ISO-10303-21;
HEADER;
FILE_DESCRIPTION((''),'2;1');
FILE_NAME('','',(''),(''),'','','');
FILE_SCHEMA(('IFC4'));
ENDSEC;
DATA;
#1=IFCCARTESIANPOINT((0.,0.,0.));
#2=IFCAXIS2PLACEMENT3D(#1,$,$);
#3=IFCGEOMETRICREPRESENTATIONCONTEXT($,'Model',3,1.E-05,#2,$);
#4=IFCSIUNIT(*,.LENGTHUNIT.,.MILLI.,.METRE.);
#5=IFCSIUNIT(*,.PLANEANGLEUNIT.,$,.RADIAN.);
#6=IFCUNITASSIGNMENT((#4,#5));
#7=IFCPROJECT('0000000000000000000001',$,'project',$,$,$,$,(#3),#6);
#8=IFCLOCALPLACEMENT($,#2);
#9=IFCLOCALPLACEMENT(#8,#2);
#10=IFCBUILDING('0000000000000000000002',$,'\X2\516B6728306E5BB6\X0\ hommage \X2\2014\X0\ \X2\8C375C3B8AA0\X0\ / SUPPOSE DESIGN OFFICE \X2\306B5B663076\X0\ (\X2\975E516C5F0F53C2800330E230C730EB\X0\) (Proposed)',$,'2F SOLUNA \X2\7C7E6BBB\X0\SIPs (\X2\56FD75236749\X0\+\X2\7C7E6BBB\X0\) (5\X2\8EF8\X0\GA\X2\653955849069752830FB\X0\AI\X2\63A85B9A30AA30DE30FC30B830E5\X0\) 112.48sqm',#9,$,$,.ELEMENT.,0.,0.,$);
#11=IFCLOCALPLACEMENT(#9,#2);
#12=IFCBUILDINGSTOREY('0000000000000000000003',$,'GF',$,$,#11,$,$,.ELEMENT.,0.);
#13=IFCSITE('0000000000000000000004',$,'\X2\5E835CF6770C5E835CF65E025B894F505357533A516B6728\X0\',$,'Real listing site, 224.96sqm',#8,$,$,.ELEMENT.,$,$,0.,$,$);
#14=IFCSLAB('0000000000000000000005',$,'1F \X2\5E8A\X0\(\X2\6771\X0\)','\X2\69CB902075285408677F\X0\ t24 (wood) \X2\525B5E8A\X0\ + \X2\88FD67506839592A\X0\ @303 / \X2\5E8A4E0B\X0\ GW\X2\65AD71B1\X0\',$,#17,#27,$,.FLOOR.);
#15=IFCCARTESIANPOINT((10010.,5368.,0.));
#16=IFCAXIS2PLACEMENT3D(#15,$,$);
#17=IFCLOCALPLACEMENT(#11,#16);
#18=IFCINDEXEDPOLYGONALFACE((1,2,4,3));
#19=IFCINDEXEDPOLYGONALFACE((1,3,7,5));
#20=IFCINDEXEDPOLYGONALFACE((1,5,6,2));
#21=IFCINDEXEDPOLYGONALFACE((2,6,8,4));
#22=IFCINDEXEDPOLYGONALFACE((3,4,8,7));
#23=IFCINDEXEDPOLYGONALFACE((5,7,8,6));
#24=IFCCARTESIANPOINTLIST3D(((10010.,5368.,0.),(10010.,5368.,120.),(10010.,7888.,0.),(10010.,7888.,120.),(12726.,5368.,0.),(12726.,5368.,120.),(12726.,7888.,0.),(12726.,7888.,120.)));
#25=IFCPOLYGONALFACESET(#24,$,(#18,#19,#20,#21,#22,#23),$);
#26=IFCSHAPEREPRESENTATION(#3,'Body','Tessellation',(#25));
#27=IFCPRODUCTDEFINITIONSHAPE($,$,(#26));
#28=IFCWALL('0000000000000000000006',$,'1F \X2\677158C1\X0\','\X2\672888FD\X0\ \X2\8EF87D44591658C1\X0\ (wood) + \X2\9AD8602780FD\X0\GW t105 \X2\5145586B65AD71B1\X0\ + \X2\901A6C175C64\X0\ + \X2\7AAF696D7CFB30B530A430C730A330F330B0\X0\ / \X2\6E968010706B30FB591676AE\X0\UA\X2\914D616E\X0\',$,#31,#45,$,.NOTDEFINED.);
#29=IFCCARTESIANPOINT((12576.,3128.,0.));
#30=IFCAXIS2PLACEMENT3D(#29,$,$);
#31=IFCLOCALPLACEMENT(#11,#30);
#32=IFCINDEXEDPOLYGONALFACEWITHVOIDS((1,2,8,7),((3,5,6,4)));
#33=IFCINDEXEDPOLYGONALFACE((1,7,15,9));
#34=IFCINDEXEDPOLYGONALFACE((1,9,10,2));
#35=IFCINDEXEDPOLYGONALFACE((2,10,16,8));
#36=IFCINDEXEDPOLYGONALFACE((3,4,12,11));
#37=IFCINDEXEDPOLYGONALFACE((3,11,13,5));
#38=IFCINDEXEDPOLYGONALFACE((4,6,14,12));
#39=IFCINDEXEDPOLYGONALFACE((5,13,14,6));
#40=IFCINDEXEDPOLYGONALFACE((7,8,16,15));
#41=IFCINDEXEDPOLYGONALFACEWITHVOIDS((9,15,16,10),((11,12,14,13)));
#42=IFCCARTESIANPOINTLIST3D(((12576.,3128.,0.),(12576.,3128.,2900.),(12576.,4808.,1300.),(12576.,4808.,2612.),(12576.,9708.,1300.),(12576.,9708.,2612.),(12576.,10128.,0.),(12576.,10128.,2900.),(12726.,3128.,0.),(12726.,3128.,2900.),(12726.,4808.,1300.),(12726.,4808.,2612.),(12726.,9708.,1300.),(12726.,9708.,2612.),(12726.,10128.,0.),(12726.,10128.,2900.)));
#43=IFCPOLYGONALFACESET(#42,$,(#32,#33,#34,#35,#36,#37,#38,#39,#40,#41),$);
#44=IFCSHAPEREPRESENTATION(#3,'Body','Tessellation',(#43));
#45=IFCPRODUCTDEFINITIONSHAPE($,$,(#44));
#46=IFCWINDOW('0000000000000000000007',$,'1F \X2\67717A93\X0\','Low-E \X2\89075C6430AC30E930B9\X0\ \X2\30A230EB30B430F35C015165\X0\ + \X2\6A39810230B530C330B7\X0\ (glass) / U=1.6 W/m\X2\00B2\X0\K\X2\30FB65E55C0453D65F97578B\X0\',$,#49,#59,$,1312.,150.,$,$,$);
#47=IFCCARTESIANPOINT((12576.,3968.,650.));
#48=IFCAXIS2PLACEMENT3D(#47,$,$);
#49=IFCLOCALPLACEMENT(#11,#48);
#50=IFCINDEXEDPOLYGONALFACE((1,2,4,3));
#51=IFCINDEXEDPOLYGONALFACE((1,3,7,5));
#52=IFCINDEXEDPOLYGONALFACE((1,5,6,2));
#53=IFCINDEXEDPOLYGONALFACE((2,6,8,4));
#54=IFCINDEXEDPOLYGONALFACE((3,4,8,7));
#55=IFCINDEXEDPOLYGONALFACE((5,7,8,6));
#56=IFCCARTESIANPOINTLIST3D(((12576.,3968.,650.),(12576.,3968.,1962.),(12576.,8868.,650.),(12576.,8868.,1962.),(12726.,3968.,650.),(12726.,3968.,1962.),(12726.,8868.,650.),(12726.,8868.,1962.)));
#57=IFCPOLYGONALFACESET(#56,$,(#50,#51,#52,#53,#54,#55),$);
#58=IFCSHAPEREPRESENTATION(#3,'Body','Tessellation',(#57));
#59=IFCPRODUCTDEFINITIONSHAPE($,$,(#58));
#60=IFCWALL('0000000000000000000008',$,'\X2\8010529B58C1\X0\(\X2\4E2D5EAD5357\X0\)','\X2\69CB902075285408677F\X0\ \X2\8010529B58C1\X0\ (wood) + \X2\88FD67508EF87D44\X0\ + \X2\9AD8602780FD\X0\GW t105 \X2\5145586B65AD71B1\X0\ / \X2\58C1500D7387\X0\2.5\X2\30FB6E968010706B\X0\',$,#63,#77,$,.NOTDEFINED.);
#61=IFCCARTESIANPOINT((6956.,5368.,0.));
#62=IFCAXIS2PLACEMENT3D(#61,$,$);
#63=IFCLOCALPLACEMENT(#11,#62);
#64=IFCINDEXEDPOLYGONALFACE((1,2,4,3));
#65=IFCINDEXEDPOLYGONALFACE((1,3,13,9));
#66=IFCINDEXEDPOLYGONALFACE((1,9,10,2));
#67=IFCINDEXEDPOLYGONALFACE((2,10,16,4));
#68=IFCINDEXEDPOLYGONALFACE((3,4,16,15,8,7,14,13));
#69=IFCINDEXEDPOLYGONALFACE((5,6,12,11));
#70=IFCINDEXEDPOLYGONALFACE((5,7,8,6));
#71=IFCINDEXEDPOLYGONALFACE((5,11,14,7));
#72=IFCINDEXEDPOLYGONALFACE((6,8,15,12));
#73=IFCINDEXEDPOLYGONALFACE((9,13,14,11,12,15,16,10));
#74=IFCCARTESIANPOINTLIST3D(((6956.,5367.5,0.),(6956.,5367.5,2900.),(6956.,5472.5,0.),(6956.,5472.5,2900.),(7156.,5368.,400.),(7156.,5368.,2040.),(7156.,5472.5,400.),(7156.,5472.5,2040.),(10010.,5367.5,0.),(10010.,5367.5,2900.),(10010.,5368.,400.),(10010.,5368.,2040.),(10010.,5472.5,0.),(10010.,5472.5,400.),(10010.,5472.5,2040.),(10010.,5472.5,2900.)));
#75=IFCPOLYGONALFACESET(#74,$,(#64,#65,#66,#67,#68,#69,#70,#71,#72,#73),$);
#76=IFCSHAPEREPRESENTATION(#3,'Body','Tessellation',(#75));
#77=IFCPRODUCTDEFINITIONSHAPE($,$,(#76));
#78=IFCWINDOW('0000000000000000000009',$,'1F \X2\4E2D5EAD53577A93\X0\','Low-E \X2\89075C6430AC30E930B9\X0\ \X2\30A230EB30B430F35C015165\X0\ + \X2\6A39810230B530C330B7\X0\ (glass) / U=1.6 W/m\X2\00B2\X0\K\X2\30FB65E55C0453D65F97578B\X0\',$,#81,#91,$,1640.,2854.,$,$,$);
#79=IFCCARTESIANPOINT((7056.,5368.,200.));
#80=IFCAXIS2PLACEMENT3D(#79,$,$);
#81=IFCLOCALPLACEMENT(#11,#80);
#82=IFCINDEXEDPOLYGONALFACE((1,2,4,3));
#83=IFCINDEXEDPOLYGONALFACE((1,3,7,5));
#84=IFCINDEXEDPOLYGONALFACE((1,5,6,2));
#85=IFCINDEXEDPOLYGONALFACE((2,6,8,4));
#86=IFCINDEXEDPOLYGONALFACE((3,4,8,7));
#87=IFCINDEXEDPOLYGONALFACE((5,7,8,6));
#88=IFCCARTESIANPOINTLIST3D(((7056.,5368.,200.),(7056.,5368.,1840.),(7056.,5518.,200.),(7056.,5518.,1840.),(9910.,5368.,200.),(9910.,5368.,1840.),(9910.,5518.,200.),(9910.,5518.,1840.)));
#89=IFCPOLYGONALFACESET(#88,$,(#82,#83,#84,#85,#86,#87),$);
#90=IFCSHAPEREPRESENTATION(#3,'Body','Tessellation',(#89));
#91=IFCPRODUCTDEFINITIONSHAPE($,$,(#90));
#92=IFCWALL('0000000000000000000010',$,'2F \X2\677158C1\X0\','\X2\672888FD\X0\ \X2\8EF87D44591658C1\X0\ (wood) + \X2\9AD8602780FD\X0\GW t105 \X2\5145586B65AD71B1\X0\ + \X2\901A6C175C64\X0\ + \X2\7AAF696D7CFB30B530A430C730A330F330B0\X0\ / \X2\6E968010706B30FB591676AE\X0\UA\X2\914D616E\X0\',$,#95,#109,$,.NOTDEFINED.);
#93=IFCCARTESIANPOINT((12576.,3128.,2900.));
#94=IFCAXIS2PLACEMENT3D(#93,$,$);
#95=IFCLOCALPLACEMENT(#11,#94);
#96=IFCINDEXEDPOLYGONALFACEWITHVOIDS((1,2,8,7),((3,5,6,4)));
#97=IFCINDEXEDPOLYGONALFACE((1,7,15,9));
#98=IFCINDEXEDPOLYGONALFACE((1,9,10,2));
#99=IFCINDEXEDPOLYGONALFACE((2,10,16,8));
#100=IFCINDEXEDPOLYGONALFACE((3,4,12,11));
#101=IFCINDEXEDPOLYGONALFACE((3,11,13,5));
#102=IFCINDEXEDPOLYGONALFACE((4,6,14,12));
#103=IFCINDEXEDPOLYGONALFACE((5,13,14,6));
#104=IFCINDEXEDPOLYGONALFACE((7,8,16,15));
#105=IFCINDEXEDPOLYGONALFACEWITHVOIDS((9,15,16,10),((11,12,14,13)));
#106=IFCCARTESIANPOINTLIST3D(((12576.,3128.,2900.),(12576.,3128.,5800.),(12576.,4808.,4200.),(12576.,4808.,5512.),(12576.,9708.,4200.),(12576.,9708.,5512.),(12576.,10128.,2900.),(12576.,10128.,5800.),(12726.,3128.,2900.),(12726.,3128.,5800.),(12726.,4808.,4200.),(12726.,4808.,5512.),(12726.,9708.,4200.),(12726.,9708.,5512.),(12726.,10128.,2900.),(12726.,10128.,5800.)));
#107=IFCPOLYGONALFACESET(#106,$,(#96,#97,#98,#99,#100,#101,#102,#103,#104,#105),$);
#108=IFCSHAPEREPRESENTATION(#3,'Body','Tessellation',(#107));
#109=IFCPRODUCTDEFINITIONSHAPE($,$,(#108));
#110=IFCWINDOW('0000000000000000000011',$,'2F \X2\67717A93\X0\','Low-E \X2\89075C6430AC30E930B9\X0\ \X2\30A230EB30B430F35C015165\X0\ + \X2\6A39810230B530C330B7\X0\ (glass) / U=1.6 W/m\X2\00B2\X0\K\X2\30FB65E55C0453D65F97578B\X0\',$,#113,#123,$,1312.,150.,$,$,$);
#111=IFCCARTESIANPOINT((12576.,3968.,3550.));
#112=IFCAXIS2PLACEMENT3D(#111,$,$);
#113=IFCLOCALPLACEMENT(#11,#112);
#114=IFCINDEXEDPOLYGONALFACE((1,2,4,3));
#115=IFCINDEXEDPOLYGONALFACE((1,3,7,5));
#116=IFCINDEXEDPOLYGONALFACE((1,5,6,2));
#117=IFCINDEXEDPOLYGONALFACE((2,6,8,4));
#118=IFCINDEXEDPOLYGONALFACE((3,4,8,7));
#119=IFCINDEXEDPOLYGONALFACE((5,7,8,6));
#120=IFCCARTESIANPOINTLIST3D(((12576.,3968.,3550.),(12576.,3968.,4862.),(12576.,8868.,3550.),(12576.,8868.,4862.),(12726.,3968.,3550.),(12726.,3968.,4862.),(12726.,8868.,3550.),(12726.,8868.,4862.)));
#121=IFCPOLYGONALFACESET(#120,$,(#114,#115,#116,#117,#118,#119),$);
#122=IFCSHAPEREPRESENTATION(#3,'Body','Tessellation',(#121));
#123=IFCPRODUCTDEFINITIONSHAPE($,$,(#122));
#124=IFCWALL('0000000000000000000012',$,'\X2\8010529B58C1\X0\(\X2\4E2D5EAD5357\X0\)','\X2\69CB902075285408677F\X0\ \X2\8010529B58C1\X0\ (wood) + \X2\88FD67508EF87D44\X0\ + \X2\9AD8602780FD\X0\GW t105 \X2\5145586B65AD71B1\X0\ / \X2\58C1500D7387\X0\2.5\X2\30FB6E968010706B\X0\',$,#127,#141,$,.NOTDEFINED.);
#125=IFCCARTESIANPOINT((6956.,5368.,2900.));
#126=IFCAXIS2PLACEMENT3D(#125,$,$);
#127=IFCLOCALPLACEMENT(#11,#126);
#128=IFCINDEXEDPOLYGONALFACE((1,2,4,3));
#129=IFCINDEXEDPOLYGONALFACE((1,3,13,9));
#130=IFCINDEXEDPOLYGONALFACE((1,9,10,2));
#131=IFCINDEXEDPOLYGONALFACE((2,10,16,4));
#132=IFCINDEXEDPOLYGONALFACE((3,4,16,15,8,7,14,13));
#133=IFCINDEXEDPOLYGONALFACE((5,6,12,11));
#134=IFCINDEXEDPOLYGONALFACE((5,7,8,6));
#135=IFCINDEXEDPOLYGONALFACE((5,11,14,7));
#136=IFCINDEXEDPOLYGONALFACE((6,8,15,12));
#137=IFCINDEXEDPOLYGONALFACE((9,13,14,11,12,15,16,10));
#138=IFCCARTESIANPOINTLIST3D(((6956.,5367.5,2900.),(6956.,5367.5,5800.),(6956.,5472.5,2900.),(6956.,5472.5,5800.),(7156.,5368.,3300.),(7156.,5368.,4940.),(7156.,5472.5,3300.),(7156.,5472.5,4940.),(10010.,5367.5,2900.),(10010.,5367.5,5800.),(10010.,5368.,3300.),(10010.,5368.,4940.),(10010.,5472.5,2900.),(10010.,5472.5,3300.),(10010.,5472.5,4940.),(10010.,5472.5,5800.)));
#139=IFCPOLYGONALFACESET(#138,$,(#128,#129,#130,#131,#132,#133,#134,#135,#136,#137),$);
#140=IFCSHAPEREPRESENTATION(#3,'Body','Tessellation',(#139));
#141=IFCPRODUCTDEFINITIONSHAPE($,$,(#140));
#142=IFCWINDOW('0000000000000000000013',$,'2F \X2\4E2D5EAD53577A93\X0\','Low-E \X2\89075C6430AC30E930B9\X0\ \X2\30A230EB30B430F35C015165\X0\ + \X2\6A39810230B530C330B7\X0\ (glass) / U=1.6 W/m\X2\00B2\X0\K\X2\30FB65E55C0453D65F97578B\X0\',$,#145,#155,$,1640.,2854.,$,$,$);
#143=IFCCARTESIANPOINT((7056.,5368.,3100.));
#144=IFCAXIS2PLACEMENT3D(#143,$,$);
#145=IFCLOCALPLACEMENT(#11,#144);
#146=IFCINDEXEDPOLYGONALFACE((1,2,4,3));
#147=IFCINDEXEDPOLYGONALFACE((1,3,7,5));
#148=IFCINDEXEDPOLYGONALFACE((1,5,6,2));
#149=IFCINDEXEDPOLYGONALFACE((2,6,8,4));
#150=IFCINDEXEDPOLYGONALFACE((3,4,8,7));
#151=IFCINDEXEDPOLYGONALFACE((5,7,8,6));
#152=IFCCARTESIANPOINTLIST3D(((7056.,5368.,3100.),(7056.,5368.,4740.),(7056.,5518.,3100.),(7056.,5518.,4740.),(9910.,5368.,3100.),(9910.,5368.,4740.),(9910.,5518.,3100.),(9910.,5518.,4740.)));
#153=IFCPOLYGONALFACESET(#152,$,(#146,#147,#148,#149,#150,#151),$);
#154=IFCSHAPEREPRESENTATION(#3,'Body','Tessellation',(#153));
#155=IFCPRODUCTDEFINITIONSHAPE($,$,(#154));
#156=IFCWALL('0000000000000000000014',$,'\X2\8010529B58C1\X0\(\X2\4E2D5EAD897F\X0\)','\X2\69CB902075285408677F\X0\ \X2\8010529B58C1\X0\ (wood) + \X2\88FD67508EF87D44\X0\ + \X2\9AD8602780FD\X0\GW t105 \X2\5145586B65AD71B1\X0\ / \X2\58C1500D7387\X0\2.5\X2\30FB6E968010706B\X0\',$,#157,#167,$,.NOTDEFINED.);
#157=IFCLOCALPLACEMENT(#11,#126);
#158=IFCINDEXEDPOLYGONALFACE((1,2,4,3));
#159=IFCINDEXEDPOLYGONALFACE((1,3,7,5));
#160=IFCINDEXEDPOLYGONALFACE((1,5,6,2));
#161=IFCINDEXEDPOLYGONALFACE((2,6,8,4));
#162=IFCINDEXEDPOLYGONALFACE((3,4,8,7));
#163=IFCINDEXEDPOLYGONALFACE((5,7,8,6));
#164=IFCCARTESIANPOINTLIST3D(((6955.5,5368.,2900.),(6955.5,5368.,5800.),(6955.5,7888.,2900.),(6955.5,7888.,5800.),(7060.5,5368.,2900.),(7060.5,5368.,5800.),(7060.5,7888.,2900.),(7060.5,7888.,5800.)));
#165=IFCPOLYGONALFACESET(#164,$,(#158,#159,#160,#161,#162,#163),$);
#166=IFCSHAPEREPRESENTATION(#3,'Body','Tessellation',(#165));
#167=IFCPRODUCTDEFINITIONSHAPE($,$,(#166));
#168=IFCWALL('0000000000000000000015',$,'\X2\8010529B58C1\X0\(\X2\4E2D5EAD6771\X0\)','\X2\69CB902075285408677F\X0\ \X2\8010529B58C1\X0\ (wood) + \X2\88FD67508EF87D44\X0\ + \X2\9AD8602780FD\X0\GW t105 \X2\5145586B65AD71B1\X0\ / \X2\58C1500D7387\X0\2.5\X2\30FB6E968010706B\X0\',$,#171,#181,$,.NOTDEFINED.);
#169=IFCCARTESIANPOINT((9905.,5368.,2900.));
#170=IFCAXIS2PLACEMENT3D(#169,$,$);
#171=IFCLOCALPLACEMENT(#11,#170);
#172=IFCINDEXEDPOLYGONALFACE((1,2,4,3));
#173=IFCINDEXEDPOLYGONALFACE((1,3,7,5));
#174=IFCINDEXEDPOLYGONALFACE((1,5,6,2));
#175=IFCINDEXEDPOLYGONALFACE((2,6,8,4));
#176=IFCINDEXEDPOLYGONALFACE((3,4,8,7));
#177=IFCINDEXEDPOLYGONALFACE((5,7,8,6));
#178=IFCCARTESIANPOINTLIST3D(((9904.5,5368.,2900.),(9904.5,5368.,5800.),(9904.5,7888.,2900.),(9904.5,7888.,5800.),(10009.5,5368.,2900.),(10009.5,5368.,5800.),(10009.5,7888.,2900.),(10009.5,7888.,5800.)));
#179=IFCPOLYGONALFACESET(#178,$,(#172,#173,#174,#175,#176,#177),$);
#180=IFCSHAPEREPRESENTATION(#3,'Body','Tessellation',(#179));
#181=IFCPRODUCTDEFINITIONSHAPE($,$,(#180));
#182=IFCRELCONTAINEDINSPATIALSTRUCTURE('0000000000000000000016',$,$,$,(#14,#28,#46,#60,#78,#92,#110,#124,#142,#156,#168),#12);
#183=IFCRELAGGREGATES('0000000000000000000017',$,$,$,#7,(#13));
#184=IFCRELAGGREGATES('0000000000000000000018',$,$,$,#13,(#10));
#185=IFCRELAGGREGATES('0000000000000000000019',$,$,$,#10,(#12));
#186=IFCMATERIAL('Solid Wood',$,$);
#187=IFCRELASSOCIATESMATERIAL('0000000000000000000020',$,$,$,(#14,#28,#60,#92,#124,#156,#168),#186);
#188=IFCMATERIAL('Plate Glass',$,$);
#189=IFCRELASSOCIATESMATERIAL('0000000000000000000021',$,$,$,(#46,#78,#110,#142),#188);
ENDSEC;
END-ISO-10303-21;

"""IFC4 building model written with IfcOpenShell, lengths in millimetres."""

from ifc_helpers import new_model, si_unit, frame, frame_2d, origin, place, context, project, spatial, rectangle, extrude, material, element, fill, save


model = new_model("IFC4")

# Units and contexts
model_context = context("Model", 3, precision=1e-05, world=origin())
ifc_project = project(units=[si_unit("LENGTHUNIT", "METRE", prefix="MILLI"), si_unit("PLANEANGLEUNIT", "RADIAN")], contexts=[model_context])

# Site, building, storey
site_placement = place(None, origin())
site = spatial("IfcSite", under=ifc_project, at=site_placement, Name="広島県広島市安佐南区八木", ObjectType="Real listing site, 224.96sqm", CompositionType="ELEMENT", RefElevation=0.0)
building_placement = place(site_placement, origin())
building = spatial("IfcBuilding", under=site, at=building_placement, Name="八木の家 hommage — 谷尻誠 / SUPPOSE DESIGN OFFICE に学ぶ (非公式参考モデル) (Proposed)", ObjectType="2F SOLUNA 籾殻SIPs (国産杉+籾殻) (5軸GA改善適用・AI推定オマージュ) 112.48sqm", CompositionType="ELEMENT", ElevationOfRefHeight=0.0, ElevationOfTerrain=0.0)
storey_placement = place(building_placement, origin())
storey = spatial("IfcBuildingStorey", under=building, at=storey_placement, Name="GF", CompositionType="ELEMENT", Elevation=0.0)

# Slab
ifc_material_1 = material(Name="Solid Wood")
slab_placement = place(storey_placement, frame((10010.0, 5368.0, 0.0)))
element("IfcSlab", 1, at=slab_placement, inside=storey, material=ifc_material_1, Name="1F 床(東)", Description="構造用合板 t24 (wood) 剛床 + 製材根太 @303 / 床下 GW断熱", PredefinedType="FLOOR", context=model_context, shape_type="SweptSolid", body=[
    extrude(rectangle(XDim=2716.0, YDim=2520.0, at=frame_2d((1358.0, 1260.0))), frame((10010.0, 5368.0, 0.0)), (0.0, 0.0, 1.0), 120.0),
])

# Walls, openings, windows
wall_1_placement = place(storey_placement, frame((12576.0, 3128.0, 0.0)))
wall_1 = element("IfcWall", 2, at=wall_1_placement, inside=storey, material=ifc_material_1, Name="1F 東壁", Description="木製 軸組外壁 (wood) + 高性能GW t105 充填断熱 + 通気層 + 窯業系サイディング / 準耐火・外皮UA配慮", PredefinedType="NOTDEFINED", context=model_context, shape_type="SweptSolid", body=[
    extrude(rectangle(XDim=150.0, YDim=7000.0, at=frame_2d((75.0, 3500.0))), frame((12576.0, 3128.0, 0.0)), (0.0, 0.0, 1.0), 2900.0),
])
opening_1_placement = place(storey_placement, frame((12576.0, 3968.0, 650.0)))
opening_1 = element("IfcOpeningElement", 3, at=opening_1_placement, cuts=wall_1, PredefinedType="NOTDEFINED", context=model_context, shape_type="SweptSolid", body=[
    extrude(rectangle(XDim=150.0, YDim=4900.0, at=frame_2d((75.0, 2450.0))), frame((12576.0, 3968.0, 650.0)), (0.0, 0.0, 1.0), 1312.0),
])
ifc_material_2 = material(Name="Plate Glass")
window_1_placement = place(storey_placement, frame((12576.0, 3968.0, 650.0)))
window_1 = element("IfcWindow", 4, at=window_1_placement, inside=storey, material=ifc_material_2, Name="1F 東窓", Description="Low-E 複層ガラス アルゴン封入 + 樹脂サッシ (glass) / U=1.6 W/m²K・日射取得型", OverallHeight=1312.0, OverallWidth=150.0, context=model_context, shape_type="SweptSolid", body=[
    extrude(rectangle(XDim=150.0, YDim=4900.0, at=frame_2d((75.0, 2450.0))), frame((12576.0, 3968.0, 650.0)), (0.0, 0.0, 1.0), 1312.0),
])
fill(opening_1, window_1)
wall_2_placement = place(storey_placement, frame((6956.0, 5368.0, 0.0)))
wall_2 = element("IfcWall", 5, at=wall_2_placement, inside=storey, material=ifc_material_1, Name="耐力壁(中庭南)", Description="構造用合板 耐力壁 (wood) + 製材軸組 + 高性能GW t105 充填断熱 / 壁倍率2.5・準耐火", PredefinedType="NOTDEFINED", context=model_context, shape_type="SweptSolid", body=[
    extrude(rectangle(XDim=3054.0, YDim=105.0, at=frame_2d((1527.0, 52.0))), frame((6956.0, 5368.0, 0.0)), (0.0, 0.0, 1.0), 2900.0),
])
opening_2_placement = place(storey_placement, frame((7056.0, 5368.0, 200.0)))
opening_2 = element("IfcOpeningElement", 6, at=opening_2_placement, cuts=wall_2, PredefinedType="NOTDEFINED", context=model_context, shape_type="SweptSolid", body=[
    extrude(rectangle(XDim=2854.0, YDim=150.0, at=frame_2d((1427.0, 75.0))), frame((7056.0, 5368.0, 200.0)), (0.0, 0.0, 1.0), 1640.0),
])
window_2_placement = place(storey_placement, frame((7056.0, 5368.0, 200.0)))
window_2 = element("IfcWindow", 7, at=window_2_placement, inside=storey, material=ifc_material_2, Name="1F 中庭南窓", Description="Low-E 複層ガラス アルゴン封入 + 樹脂サッシ (glass) / U=1.6 W/m²K・日射取得型", OverallHeight=1640.0, OverallWidth=2854.0, context=model_context, shape_type="SweptSolid", body=[
    extrude(rectangle(XDim=2854.0, YDim=150.0, at=frame_2d((1427.0, 75.0))), frame((7056.0, 5368.0, 200.0)), (0.0, 0.0, 1.0), 1640.0),
])
fill(opening_2, window_2)

# Walls, openings, windows
wall_3_placement = place(storey_placement, frame((12576.0, 3128.0, 2900.0)))
wall_3 = element("IfcWall", 8, at=wall_3_placement, inside=storey, material=ifc_material_1, Name="2F 東壁", Description="木製 軸組外壁 (wood) + 高性能GW t105 充填断熱 + 通気層 + 窯業系サイディング / 準耐火・外皮UA配慮", PredefinedType="NOTDEFINED", context=model_context, shape_type="SweptSolid", body=[
    extrude(rectangle(XDim=150.0, YDim=7000.0, at=frame_2d((75.0, 3500.0))), frame((12576.0, 3128.0, 2900.0)), (0.0, 0.0, 1.0), 2900.0),
])
opening_3_placement = place(storey_placement, frame((12576.0, 3968.0, 3550.0)))
opening_3 = element("IfcOpeningElement", 9, at=opening_3_placement, cuts=wall_3, PredefinedType="NOTDEFINED", context=model_context, shape_type="SweptSolid", body=[
    extrude(rectangle(XDim=150.0, YDim=4900.0, at=frame_2d((75.0, 2450.0))), frame((12576.0, 3968.0, 3550.0)), (0.0, 0.0, 1.0), 1312.0),
])
window_3_placement = place(storey_placement, frame((12576.0, 3968.0, 3550.0)))
window_3 = element("IfcWindow", 10, at=window_3_placement, inside=storey, material=ifc_material_2, Name="2F 東窓", Description="Low-E 複層ガラス アルゴン封入 + 樹脂サッシ (glass) / U=1.6 W/m²K・日射取得型", OverallHeight=1312.0, OverallWidth=150.0, context=model_context, shape_type="SweptSolid", body=[
    extrude(rectangle(XDim=150.0, YDim=4900.0, at=frame_2d((75.0, 2450.0))), frame((12576.0, 3968.0, 3550.0)), (0.0, 0.0, 1.0), 1312.0),
])
fill(opening_3, window_3)
wall_4_placement = place(storey_placement, frame((6956.0, 5368.0, 2900.0)))
wall_4 = element("IfcWall", 11, at=wall_4_placement, inside=storey, material=ifc_material_1, Name="耐力壁(中庭南)", Description="構造用合板 耐力壁 (wood) + 製材軸組 + 高性能GW t105 充填断熱 / 壁倍率2.5・準耐火", PredefinedType="NOTDEFINED", context=model_context, shape_type="SweptSolid", body=[
    extrude(rectangle(XDim=3054.0, YDim=105.0, at=frame_2d((1527.0, 52.0))), frame((6956.0, 5368.0, 2900.0)), (0.0, 0.0, 1.0), 2900.0),
])
opening_4_placement = place(storey_placement, frame((7056.0, 5368.0, 3100.0)))
opening_4 = element("IfcOpeningElement", 12, at=opening_4_placement, cuts=wall_4, PredefinedType="NOTDEFINED", context=model_context, shape_type="SweptSolid", body=[
    extrude(rectangle(XDim=2854.0, YDim=150.0, at=frame_2d((1427.0, 75.0))), frame((7056.0, 5368.0, 3100.0)), (0.0, 0.0, 1.0), 1640.0),
])
window_4_placement = place(storey_placement, frame((7056.0, 5368.0, 3100.0)))
window_4 = element("IfcWindow", 13, at=window_4_placement, inside=storey, material=ifc_material_2, Name="2F 中庭南窓", Description="Low-E 複層ガラス アルゴン封入 + 樹脂サッシ (glass) / U=1.6 W/m²K・日射取得型", OverallHeight=1640.0, OverallWidth=2854.0, context=model_context, shape_type="SweptSolid", body=[
    extrude(rectangle(XDim=2854.0, YDim=150.0, at=frame_2d((1427.0, 75.0))), frame((7056.0, 5368.0, 3100.0)), (0.0, 0.0, 1.0), 1640.0),
])
fill(opening_4, window_4)

# Walls
wall_5_placement = place(storey_placement, frame((6956.0, 5368.0, 2900.0)))
element("IfcWall", 14, at=wall_5_placement, inside=storey, material=ifc_material_1, Name="耐力壁(中庭西)", Description="構造用合板 耐力壁 (wood) + 製材軸組 + 高性能GW t105 充填断熱 / 壁倍率2.5・準耐火", PredefinedType="NOTDEFINED", context=model_context, shape_type="SweptSolid", body=[
    extrude(rectangle(XDim=105.0, YDim=2520.0, at=frame_2d((52.0, 1260.0))), frame((6956.0, 5368.0, 2900.0)), (0.0, 0.0, 1.0), 2900.0),
])
wall_6_placement = place(storey_placement, frame((9905.0, 5368.0, 2900.0)))
element("IfcWall", 15, at=wall_6_placement, inside=storey, material=ifc_material_1, Name="耐力壁(中庭東)", Description="構造用合板 耐力壁 (wood) + 製材軸組 + 高性能GW t105 充填断熱 / 壁倍率2.5・準耐火", PredefinedType="NOTDEFINED", context=model_context, shape_type="SweptSolid", body=[
    extrude(rectangle(XDim=105.0, YDim=2520.0, at=frame_2d((52.0, 1260.0))), frame((9905.0, 5368.0, 2900.0)), (0.0, 0.0, 1.0), 2900.0),
])

save(model, "model.ifc")
